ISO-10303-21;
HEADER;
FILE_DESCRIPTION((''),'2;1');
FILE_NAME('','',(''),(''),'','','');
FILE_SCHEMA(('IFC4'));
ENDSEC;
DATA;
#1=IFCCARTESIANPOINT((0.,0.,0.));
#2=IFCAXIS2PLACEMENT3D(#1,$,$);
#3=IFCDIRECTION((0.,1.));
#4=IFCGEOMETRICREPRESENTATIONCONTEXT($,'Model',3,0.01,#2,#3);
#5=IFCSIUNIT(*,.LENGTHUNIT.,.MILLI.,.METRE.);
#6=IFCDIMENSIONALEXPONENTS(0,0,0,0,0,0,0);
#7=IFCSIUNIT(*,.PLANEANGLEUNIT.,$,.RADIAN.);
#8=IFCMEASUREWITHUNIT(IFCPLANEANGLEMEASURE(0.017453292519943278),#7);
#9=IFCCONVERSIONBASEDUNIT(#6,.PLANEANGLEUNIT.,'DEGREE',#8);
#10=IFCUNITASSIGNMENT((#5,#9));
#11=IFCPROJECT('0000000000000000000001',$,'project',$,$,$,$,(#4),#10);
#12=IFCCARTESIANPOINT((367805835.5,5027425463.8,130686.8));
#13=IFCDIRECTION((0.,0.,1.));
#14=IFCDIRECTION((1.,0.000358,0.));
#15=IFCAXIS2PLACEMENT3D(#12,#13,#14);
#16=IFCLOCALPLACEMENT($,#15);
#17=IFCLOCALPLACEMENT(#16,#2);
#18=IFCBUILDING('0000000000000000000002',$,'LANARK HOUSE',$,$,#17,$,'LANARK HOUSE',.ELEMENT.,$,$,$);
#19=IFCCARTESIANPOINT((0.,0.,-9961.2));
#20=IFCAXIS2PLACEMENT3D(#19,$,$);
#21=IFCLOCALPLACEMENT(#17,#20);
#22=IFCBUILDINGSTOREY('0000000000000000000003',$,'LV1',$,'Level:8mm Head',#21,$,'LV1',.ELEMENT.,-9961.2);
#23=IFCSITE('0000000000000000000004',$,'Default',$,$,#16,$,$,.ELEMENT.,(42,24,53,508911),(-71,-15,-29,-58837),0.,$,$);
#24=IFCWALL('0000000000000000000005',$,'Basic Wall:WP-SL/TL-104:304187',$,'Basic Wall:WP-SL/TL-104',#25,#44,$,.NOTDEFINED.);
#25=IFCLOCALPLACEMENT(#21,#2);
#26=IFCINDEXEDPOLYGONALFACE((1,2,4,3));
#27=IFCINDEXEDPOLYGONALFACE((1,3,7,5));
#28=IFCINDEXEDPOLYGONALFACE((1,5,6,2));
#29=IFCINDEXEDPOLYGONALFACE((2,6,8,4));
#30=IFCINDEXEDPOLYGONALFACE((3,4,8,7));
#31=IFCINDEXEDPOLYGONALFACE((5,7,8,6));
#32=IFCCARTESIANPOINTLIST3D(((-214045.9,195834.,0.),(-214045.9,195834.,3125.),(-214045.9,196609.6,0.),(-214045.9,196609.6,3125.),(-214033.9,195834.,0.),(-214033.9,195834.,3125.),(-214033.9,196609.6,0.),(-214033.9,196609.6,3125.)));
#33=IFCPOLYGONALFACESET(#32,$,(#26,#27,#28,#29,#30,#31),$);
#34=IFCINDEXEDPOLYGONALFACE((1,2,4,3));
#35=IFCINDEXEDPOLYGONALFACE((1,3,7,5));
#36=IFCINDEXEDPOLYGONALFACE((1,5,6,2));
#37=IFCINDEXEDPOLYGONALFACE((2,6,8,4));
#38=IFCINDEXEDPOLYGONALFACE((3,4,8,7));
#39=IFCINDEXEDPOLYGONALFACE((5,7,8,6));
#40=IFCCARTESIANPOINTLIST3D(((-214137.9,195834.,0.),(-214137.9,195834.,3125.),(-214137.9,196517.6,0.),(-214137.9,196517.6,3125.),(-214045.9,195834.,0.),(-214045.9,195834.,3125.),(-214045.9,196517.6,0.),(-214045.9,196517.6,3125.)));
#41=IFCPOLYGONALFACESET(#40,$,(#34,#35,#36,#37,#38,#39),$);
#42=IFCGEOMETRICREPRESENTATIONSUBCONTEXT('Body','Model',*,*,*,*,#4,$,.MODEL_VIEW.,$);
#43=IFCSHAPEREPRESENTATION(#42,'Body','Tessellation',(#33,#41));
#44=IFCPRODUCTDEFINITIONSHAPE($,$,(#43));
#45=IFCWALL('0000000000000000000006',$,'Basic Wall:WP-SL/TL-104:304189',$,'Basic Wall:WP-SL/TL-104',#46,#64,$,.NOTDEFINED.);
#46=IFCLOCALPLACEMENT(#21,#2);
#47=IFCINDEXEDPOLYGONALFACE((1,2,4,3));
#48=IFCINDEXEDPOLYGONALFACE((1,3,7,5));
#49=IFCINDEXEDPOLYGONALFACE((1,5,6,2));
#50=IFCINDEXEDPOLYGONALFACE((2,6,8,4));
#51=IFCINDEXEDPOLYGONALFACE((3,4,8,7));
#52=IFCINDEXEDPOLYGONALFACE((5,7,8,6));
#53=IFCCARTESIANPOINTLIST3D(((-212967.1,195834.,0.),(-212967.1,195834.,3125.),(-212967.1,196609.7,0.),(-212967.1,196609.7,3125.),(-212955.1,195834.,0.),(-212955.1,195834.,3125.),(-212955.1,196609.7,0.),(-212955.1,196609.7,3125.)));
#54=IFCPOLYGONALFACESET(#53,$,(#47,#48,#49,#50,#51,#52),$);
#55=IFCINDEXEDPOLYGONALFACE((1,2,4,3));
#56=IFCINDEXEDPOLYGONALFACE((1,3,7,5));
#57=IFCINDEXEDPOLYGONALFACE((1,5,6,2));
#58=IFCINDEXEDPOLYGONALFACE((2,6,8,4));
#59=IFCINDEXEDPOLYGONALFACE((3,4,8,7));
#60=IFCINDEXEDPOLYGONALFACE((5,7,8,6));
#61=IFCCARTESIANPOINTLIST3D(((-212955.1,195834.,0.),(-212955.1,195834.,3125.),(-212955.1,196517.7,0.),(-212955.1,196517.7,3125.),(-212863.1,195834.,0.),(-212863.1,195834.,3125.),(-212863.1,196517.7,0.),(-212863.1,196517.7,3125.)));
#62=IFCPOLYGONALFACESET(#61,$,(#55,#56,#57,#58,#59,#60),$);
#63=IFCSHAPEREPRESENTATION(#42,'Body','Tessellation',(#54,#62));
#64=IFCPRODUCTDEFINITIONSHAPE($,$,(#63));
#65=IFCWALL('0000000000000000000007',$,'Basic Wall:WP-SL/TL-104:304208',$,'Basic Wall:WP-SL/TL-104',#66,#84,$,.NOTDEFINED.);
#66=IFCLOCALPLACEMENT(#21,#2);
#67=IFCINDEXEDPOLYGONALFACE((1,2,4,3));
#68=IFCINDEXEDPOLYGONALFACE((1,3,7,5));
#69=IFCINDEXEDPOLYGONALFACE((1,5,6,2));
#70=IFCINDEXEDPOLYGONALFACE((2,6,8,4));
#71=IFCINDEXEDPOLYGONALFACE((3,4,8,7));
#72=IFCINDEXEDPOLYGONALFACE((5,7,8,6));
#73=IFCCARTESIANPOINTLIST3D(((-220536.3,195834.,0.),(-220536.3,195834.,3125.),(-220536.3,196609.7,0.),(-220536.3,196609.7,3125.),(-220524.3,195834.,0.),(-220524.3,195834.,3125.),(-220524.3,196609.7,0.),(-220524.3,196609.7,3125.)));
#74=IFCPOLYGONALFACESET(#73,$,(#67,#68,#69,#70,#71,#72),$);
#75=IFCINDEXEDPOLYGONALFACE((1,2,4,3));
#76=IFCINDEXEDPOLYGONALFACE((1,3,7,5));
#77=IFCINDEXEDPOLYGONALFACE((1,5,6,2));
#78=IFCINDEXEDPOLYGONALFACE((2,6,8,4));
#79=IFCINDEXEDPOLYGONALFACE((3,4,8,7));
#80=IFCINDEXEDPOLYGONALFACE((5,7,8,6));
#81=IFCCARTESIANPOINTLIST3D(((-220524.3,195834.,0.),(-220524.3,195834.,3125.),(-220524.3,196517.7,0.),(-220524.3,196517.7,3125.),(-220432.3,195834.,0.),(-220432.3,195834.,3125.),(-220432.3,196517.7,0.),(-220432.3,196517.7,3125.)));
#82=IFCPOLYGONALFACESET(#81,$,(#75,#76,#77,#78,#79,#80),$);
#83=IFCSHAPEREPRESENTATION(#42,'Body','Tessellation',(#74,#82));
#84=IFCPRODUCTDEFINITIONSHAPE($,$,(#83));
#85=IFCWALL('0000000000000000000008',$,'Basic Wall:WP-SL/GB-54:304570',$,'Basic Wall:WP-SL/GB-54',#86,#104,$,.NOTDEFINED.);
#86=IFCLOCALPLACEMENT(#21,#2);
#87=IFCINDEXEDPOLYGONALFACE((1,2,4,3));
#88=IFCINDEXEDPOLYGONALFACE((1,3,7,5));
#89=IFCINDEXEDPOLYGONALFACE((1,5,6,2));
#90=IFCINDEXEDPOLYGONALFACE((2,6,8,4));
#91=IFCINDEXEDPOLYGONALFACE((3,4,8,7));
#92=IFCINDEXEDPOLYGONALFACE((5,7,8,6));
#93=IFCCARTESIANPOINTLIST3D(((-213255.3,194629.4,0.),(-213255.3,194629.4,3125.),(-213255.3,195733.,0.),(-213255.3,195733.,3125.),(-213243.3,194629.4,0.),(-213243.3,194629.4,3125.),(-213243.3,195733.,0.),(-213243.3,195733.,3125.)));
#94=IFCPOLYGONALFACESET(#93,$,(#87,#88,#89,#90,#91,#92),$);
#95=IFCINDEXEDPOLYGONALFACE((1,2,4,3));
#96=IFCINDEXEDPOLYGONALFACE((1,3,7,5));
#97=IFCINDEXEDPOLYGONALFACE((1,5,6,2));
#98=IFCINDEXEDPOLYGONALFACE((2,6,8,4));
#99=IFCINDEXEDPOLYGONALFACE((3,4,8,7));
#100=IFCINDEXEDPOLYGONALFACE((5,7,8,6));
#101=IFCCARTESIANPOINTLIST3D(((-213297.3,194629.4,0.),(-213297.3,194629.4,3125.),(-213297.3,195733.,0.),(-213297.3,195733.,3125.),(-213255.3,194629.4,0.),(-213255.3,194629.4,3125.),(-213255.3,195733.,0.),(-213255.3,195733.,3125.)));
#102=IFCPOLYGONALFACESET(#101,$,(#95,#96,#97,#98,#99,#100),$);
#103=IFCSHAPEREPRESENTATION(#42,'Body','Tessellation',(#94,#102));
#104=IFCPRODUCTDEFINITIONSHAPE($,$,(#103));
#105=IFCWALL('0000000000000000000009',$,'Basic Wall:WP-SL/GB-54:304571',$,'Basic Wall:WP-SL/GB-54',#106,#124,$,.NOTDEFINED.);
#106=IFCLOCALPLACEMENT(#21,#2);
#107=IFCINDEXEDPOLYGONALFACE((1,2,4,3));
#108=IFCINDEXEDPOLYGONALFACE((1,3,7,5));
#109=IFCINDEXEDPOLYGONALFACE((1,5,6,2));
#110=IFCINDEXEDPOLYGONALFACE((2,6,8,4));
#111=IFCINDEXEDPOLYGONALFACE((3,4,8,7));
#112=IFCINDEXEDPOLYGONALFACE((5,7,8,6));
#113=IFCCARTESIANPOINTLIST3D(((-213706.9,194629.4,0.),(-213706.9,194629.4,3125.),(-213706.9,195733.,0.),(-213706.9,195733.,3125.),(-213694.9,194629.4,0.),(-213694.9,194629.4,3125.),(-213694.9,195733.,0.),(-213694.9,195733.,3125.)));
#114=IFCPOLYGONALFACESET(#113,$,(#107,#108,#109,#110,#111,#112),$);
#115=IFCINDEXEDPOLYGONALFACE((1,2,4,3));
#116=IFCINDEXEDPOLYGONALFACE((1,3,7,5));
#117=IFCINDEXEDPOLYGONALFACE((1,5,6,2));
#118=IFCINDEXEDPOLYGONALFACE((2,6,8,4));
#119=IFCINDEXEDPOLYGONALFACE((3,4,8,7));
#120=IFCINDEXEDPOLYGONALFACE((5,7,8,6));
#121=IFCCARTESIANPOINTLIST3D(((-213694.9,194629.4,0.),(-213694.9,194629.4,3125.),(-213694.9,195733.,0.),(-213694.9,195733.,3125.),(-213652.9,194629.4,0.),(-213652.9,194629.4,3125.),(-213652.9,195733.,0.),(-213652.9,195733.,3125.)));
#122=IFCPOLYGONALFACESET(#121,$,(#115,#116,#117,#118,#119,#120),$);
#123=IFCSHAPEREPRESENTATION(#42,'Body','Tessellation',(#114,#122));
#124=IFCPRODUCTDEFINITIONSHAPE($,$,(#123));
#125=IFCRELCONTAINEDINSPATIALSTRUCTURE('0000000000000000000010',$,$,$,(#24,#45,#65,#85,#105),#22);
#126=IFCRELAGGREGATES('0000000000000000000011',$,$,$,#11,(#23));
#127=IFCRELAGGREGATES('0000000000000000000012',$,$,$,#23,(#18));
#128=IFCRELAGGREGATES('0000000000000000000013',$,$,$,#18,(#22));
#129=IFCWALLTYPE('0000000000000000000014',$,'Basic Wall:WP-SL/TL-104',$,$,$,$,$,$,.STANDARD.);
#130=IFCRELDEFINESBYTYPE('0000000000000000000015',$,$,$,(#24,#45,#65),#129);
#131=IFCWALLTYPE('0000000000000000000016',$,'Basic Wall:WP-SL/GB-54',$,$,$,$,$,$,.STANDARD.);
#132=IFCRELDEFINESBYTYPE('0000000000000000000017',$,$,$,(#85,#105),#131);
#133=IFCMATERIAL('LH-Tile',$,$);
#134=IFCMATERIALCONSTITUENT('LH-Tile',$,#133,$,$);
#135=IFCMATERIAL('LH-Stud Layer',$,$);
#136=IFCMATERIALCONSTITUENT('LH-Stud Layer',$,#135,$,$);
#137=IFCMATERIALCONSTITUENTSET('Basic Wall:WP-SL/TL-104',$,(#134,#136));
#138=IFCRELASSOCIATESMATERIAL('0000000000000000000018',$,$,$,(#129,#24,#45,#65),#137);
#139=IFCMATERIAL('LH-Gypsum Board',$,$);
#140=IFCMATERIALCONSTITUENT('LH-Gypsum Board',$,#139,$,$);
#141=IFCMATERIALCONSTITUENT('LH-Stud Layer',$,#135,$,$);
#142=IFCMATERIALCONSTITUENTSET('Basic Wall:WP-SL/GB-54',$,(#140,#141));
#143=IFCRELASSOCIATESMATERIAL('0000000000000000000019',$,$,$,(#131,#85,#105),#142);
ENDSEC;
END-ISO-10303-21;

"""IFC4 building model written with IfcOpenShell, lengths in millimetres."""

from ifc_helpers import new_model, entity, si_unit, converted_unit, direction, frame, origin, place, context, subcontext, project, spatial, indexed_curve, outline, extrude, material, constituent, constituent_set, type_object, element, save


model = new_model("IFC4")

# Units and contexts
model_context = context("Model", 3, precision=0.01, world=origin(), true_north=direction((0.0, 1.0)))
body_context = subcontext(model_context, "Body", "Model", "MODEL_VIEW")
ifc_project = project(units=[si_unit("LENGTHUNIT", "METRE", prefix="MILLI"), converted_unit("PLANEANGLEUNIT", "DEGREE", entity("IfcPlaneAngleMeasure", 0.017453292519943278), si_unit("PLANEANGLEUNIT", "RADIAN"), dimensions=[0, 0, 0, 0, 0, 0, 0])], contexts=[model_context])

# Site, building, storey
site_placement = place(None, frame((367805835.5, 5027425463.8, 130686.8), z_axis=(0.0, 0.0, 1.0), x_axis=(1.0, 0.000358, 0.0)))
site = spatial("IfcSite", under=ifc_project, at=site_placement, Name="Default", CompositionType="ELEMENT", RefLatitude=(42, 24, 53, 508911), RefLongitude=(-71, -15, -29, -58837), RefElevation=0.0)
building_placement = place(site_placement, origin())
building = spatial("IfcBuilding", under=site, at=building_placement, Name="LANARK HOUSE", LongName="LANARK HOUSE", CompositionType="ELEMENT")
storey_placement = place(building_placement, frame((0.0, 0.0, -9961.2)))
storey = spatial("IfcBuildingStorey", under=building, at=storey_placement, Name="LV1", ObjectType="Level:8mm Head", LongName="LV1", CompositionType="ELEMENT", Elevation=-9961.2)

# Walls
ifc_material_1 = material(Name="LH-Tile")
ifc_constituent_1 = constituent(ifc_material_1, Name="LH-Tile")
ifc_material_2 = material(Name="LH-Stud Layer")
ifc_constituent_2 = constituent(ifc_material_2, Name="LH-Stud Layer")
ifc_constituent_set_1 = constituent_set(constituents=[ifc_constituent_1, ifc_constituent_2], Name="Basic Wall:WP-SL/TL-104")
wall_type_1 = type_object("IfcWallType", Name="Basic Wall:WP-SL/TL-104", PredefinedType="STANDARD", material=ifc_constituent_set_1)
wall_1_placement = place(storey_placement, frame((-214085.9, 196517.6, 0.0), z_axis=(0.0, 0.0, 1.0), x_axis=(0.0, -1.0, 0.0)))
element("IfcWall", 1, at=wall_1_placement, inside=storey, type_object=wall_type_1, material=ifc_constituent_set_1, Name="Basic Wall:WP-SL/TL-104:304187", ObjectType="Basic Wall:WP-SL/TL-104", PredefinedType="NOTDEFINED", context=body_context, shape_type="SweptSolid", body=[
    extrude(outline(indexed_curve([(-6.0, -387.8), (6.0, -387.8), (6.0, 387.8), (-6.0, 387.8), (-6.0, -387.8)], self_intersect=False)), frame((295.8, 46.0, 0.0), z_axis=(0.0, 0.0, 1.0), x_axis=(0.0, -1.0, 0.0)), (0.0, 0.0, 1.0), 3125.0),
    extrude(outline(indexed_curve([(-46.0, -341.8), (46.0, -341.8), (46.0, 341.8), (-46.0, 341.8), (-46.0, -341.8)], self_intersect=False)), frame((341.8, -6.0, 0.0), z_axis=(0.0, 0.0, 1.0), x_axis=(0.0, 1.0, 0.0)), (0.0, 0.0, 1.0), 3125.0),
])
wall_2_placement = place(storey_placement, frame((-212915.1, 195834.0, 0.0), z_axis=(0.0, 0.0, 1.0), x_axis=(0.0, 1.0, 0.0)))
element("IfcWall", 2, at=wall_2_placement, inside=storey, type_object=wall_type_1, material=ifc_constituent_set_1, Name="Basic Wall:WP-SL/TL-104:304189", ObjectType="Basic Wall:WP-SL/TL-104", PredefinedType="NOTDEFINED", context=body_context, shape_type="SweptSolid", body=[
    extrude(outline(indexed_curve([(-6.0, -387.8), (6.0, -387.8), (6.0, 387.8), (-6.0, 387.8), (-6.0, -387.8)], self_intersect=False)), frame((387.8, 46.0, 0.0), z_axis=(0.0, 0.0, 1.0), x_axis=(0.0, -1.0, 0.0)), (0.0, 0.0, 1.0), 3125.0),
    extrude(outline(indexed_curve([(-46.0, -341.8), (46.0, -341.8), (46.0, 341.8), (-46.0, 341.8), (-46.0, -341.8)], self_intersect=False)), frame((341.8, -6.0, 0.0), z_axis=(0.0, 0.0, 1.0), x_axis=(0.0, 1.0, 0.0)), (0.0, 0.0, 1.0), 3125.0),
])
wall_3_placement = place(storey_placement, frame((-220484.3, 195834.0, 0.0), z_axis=(0.0, 0.0, 1.0), x_axis=(0.0, 1.0, 0.0)))
element("IfcWall", 3, at=wall_3_placement, inside=storey, type_object=wall_type_1, material=ifc_constituent_set_1, Name="Basic Wall:WP-SL/TL-104:304208", ObjectType="Basic Wall:WP-SL/TL-104", PredefinedType="NOTDEFINED", context=body_context, shape_type="SweptSolid", body=[
    extrude(outline(indexed_curve([(-6.0, -387.8), (6.0, -387.8), (6.0, 387.8), (-6.0, 387.8), (-6.0, -387.8)], self_intersect=False)), frame((387.8, 46.0, 0.0), z_axis=(0.0, 0.0, 1.0), x_axis=(0.0, -1.0, 0.0)), (0.0, 0.0, 1.0), 3125.0),
    extrude(outline(indexed_curve([(-46.0, -341.8), (46.0, -341.8), (46.0, 341.8), (-46.0, 341.8), (-46.0, -341.8)], self_intersect=False)), frame((341.8, -6.0, 0.0), z_axis=(0.0, 0.0, 1.0), x_axis=(0.0, 1.0, 0.0)), (0.0, 0.0, 1.0), 3125.0),
])
ifc_material_3 = material(Name="LH-Gypsum Board")
ifc_constituent_3 = constituent(ifc_material_3, Name="LH-Gypsum Board")
ifc_constituent_4 = constituent(ifc_material_2, Name="LH-Stud Layer")
ifc_constituent_set_2 = constituent_set(constituents=[ifc_constituent_3, ifc_constituent_4], Name="Basic Wall:WP-SL/GB-54")
wall_type_2 = type_object("IfcWallType", Name="Basic Wall:WP-SL/GB-54", PredefinedType="STANDARD", material=ifc_constituent_set_2)
wall_4_placement = place(storey_placement, frame((-213270.3, 195733.0, 0.0), z_axis=(0.0, 0.0, 1.0), x_axis=(0.0, -1.0, 0.0)))
element("IfcWall", 4, at=wall_4_placement, inside=storey, type_object=wall_type_2, material=ifc_constituent_set_2, Name="Basic Wall:WP-SL/GB-54:304570", ObjectType="Basic Wall:WP-SL/GB-54", PredefinedType="NOTDEFINED", context=body_context, shape_type="SweptSolid", body=[
    extrude(outline(indexed_curve([(-6.0, -551.8), (6.0, -551.8), (6.0, 551.8), (-6.0, 551.8), (-6.0, -551.8)], self_intersect=False)), frame((551.8, 21.0, 0.0), z_axis=(0.0, 0.0, 1.0), x_axis=(0.0, -1.0, 0.0)), (0.0, 0.0, 1.0), 3125.0),
    extrude(outline(indexed_curve([(-21.0, -551.8), (21.0, -551.8), (21.0, 551.8), (-21.0, 551.8), (-21.0, -551.8)], self_intersect=False)), frame((551.8, -6.0, 0.0), z_axis=(0.0, 0.0, 1.0), x_axis=(0.0, 1.0, 0.0)), (0.0, 0.0, 1.0), 3125.0),
])
wall_5_placement = place(storey_placement, frame((-213679.9, 194629.4, 0.0), z_axis=(0.0, 0.0, 1.0), x_axis=(0.0, 1.0, 0.0)))
element("IfcWall", 5, at=wall_5_placement, inside=storey, type_object=wall_type_2, material=ifc_constituent_set_2, Name="Basic Wall:WP-SL/GB-54:304571", ObjectType="Basic Wall:WP-SL/GB-54", PredefinedType="NOTDEFINED", context=body_context, shape_type="SweptSolid", body=[
    extrude(outline(indexed_curve([(-6.0, -551.8), (6.0, -551.8), (6.0, 551.8), (-6.0, 551.8), (-6.0, -551.8)], self_intersect=False)), frame((551.8, 21.0, 0.0), z_axis=(0.0, 0.0, 1.0), x_axis=(0.0, -1.0, 0.0)), (0.0, 0.0, 1.0), 3125.0),
    extrude(outline(indexed_curve([(-21.0, -551.8), (21.0, -551.8), (21.0, 551.8), (-21.0, 551.8), (-21.0, -551.8)], self_intersect=False)), frame((551.8, -6.0, 0.0), z_axis=(0.0, 0.0, 1.0), x_axis=(0.0, 1.0, 0.0)), (0.0, 0.0, 1.0), 3125.0),
])

save(model, "model.ifc")
